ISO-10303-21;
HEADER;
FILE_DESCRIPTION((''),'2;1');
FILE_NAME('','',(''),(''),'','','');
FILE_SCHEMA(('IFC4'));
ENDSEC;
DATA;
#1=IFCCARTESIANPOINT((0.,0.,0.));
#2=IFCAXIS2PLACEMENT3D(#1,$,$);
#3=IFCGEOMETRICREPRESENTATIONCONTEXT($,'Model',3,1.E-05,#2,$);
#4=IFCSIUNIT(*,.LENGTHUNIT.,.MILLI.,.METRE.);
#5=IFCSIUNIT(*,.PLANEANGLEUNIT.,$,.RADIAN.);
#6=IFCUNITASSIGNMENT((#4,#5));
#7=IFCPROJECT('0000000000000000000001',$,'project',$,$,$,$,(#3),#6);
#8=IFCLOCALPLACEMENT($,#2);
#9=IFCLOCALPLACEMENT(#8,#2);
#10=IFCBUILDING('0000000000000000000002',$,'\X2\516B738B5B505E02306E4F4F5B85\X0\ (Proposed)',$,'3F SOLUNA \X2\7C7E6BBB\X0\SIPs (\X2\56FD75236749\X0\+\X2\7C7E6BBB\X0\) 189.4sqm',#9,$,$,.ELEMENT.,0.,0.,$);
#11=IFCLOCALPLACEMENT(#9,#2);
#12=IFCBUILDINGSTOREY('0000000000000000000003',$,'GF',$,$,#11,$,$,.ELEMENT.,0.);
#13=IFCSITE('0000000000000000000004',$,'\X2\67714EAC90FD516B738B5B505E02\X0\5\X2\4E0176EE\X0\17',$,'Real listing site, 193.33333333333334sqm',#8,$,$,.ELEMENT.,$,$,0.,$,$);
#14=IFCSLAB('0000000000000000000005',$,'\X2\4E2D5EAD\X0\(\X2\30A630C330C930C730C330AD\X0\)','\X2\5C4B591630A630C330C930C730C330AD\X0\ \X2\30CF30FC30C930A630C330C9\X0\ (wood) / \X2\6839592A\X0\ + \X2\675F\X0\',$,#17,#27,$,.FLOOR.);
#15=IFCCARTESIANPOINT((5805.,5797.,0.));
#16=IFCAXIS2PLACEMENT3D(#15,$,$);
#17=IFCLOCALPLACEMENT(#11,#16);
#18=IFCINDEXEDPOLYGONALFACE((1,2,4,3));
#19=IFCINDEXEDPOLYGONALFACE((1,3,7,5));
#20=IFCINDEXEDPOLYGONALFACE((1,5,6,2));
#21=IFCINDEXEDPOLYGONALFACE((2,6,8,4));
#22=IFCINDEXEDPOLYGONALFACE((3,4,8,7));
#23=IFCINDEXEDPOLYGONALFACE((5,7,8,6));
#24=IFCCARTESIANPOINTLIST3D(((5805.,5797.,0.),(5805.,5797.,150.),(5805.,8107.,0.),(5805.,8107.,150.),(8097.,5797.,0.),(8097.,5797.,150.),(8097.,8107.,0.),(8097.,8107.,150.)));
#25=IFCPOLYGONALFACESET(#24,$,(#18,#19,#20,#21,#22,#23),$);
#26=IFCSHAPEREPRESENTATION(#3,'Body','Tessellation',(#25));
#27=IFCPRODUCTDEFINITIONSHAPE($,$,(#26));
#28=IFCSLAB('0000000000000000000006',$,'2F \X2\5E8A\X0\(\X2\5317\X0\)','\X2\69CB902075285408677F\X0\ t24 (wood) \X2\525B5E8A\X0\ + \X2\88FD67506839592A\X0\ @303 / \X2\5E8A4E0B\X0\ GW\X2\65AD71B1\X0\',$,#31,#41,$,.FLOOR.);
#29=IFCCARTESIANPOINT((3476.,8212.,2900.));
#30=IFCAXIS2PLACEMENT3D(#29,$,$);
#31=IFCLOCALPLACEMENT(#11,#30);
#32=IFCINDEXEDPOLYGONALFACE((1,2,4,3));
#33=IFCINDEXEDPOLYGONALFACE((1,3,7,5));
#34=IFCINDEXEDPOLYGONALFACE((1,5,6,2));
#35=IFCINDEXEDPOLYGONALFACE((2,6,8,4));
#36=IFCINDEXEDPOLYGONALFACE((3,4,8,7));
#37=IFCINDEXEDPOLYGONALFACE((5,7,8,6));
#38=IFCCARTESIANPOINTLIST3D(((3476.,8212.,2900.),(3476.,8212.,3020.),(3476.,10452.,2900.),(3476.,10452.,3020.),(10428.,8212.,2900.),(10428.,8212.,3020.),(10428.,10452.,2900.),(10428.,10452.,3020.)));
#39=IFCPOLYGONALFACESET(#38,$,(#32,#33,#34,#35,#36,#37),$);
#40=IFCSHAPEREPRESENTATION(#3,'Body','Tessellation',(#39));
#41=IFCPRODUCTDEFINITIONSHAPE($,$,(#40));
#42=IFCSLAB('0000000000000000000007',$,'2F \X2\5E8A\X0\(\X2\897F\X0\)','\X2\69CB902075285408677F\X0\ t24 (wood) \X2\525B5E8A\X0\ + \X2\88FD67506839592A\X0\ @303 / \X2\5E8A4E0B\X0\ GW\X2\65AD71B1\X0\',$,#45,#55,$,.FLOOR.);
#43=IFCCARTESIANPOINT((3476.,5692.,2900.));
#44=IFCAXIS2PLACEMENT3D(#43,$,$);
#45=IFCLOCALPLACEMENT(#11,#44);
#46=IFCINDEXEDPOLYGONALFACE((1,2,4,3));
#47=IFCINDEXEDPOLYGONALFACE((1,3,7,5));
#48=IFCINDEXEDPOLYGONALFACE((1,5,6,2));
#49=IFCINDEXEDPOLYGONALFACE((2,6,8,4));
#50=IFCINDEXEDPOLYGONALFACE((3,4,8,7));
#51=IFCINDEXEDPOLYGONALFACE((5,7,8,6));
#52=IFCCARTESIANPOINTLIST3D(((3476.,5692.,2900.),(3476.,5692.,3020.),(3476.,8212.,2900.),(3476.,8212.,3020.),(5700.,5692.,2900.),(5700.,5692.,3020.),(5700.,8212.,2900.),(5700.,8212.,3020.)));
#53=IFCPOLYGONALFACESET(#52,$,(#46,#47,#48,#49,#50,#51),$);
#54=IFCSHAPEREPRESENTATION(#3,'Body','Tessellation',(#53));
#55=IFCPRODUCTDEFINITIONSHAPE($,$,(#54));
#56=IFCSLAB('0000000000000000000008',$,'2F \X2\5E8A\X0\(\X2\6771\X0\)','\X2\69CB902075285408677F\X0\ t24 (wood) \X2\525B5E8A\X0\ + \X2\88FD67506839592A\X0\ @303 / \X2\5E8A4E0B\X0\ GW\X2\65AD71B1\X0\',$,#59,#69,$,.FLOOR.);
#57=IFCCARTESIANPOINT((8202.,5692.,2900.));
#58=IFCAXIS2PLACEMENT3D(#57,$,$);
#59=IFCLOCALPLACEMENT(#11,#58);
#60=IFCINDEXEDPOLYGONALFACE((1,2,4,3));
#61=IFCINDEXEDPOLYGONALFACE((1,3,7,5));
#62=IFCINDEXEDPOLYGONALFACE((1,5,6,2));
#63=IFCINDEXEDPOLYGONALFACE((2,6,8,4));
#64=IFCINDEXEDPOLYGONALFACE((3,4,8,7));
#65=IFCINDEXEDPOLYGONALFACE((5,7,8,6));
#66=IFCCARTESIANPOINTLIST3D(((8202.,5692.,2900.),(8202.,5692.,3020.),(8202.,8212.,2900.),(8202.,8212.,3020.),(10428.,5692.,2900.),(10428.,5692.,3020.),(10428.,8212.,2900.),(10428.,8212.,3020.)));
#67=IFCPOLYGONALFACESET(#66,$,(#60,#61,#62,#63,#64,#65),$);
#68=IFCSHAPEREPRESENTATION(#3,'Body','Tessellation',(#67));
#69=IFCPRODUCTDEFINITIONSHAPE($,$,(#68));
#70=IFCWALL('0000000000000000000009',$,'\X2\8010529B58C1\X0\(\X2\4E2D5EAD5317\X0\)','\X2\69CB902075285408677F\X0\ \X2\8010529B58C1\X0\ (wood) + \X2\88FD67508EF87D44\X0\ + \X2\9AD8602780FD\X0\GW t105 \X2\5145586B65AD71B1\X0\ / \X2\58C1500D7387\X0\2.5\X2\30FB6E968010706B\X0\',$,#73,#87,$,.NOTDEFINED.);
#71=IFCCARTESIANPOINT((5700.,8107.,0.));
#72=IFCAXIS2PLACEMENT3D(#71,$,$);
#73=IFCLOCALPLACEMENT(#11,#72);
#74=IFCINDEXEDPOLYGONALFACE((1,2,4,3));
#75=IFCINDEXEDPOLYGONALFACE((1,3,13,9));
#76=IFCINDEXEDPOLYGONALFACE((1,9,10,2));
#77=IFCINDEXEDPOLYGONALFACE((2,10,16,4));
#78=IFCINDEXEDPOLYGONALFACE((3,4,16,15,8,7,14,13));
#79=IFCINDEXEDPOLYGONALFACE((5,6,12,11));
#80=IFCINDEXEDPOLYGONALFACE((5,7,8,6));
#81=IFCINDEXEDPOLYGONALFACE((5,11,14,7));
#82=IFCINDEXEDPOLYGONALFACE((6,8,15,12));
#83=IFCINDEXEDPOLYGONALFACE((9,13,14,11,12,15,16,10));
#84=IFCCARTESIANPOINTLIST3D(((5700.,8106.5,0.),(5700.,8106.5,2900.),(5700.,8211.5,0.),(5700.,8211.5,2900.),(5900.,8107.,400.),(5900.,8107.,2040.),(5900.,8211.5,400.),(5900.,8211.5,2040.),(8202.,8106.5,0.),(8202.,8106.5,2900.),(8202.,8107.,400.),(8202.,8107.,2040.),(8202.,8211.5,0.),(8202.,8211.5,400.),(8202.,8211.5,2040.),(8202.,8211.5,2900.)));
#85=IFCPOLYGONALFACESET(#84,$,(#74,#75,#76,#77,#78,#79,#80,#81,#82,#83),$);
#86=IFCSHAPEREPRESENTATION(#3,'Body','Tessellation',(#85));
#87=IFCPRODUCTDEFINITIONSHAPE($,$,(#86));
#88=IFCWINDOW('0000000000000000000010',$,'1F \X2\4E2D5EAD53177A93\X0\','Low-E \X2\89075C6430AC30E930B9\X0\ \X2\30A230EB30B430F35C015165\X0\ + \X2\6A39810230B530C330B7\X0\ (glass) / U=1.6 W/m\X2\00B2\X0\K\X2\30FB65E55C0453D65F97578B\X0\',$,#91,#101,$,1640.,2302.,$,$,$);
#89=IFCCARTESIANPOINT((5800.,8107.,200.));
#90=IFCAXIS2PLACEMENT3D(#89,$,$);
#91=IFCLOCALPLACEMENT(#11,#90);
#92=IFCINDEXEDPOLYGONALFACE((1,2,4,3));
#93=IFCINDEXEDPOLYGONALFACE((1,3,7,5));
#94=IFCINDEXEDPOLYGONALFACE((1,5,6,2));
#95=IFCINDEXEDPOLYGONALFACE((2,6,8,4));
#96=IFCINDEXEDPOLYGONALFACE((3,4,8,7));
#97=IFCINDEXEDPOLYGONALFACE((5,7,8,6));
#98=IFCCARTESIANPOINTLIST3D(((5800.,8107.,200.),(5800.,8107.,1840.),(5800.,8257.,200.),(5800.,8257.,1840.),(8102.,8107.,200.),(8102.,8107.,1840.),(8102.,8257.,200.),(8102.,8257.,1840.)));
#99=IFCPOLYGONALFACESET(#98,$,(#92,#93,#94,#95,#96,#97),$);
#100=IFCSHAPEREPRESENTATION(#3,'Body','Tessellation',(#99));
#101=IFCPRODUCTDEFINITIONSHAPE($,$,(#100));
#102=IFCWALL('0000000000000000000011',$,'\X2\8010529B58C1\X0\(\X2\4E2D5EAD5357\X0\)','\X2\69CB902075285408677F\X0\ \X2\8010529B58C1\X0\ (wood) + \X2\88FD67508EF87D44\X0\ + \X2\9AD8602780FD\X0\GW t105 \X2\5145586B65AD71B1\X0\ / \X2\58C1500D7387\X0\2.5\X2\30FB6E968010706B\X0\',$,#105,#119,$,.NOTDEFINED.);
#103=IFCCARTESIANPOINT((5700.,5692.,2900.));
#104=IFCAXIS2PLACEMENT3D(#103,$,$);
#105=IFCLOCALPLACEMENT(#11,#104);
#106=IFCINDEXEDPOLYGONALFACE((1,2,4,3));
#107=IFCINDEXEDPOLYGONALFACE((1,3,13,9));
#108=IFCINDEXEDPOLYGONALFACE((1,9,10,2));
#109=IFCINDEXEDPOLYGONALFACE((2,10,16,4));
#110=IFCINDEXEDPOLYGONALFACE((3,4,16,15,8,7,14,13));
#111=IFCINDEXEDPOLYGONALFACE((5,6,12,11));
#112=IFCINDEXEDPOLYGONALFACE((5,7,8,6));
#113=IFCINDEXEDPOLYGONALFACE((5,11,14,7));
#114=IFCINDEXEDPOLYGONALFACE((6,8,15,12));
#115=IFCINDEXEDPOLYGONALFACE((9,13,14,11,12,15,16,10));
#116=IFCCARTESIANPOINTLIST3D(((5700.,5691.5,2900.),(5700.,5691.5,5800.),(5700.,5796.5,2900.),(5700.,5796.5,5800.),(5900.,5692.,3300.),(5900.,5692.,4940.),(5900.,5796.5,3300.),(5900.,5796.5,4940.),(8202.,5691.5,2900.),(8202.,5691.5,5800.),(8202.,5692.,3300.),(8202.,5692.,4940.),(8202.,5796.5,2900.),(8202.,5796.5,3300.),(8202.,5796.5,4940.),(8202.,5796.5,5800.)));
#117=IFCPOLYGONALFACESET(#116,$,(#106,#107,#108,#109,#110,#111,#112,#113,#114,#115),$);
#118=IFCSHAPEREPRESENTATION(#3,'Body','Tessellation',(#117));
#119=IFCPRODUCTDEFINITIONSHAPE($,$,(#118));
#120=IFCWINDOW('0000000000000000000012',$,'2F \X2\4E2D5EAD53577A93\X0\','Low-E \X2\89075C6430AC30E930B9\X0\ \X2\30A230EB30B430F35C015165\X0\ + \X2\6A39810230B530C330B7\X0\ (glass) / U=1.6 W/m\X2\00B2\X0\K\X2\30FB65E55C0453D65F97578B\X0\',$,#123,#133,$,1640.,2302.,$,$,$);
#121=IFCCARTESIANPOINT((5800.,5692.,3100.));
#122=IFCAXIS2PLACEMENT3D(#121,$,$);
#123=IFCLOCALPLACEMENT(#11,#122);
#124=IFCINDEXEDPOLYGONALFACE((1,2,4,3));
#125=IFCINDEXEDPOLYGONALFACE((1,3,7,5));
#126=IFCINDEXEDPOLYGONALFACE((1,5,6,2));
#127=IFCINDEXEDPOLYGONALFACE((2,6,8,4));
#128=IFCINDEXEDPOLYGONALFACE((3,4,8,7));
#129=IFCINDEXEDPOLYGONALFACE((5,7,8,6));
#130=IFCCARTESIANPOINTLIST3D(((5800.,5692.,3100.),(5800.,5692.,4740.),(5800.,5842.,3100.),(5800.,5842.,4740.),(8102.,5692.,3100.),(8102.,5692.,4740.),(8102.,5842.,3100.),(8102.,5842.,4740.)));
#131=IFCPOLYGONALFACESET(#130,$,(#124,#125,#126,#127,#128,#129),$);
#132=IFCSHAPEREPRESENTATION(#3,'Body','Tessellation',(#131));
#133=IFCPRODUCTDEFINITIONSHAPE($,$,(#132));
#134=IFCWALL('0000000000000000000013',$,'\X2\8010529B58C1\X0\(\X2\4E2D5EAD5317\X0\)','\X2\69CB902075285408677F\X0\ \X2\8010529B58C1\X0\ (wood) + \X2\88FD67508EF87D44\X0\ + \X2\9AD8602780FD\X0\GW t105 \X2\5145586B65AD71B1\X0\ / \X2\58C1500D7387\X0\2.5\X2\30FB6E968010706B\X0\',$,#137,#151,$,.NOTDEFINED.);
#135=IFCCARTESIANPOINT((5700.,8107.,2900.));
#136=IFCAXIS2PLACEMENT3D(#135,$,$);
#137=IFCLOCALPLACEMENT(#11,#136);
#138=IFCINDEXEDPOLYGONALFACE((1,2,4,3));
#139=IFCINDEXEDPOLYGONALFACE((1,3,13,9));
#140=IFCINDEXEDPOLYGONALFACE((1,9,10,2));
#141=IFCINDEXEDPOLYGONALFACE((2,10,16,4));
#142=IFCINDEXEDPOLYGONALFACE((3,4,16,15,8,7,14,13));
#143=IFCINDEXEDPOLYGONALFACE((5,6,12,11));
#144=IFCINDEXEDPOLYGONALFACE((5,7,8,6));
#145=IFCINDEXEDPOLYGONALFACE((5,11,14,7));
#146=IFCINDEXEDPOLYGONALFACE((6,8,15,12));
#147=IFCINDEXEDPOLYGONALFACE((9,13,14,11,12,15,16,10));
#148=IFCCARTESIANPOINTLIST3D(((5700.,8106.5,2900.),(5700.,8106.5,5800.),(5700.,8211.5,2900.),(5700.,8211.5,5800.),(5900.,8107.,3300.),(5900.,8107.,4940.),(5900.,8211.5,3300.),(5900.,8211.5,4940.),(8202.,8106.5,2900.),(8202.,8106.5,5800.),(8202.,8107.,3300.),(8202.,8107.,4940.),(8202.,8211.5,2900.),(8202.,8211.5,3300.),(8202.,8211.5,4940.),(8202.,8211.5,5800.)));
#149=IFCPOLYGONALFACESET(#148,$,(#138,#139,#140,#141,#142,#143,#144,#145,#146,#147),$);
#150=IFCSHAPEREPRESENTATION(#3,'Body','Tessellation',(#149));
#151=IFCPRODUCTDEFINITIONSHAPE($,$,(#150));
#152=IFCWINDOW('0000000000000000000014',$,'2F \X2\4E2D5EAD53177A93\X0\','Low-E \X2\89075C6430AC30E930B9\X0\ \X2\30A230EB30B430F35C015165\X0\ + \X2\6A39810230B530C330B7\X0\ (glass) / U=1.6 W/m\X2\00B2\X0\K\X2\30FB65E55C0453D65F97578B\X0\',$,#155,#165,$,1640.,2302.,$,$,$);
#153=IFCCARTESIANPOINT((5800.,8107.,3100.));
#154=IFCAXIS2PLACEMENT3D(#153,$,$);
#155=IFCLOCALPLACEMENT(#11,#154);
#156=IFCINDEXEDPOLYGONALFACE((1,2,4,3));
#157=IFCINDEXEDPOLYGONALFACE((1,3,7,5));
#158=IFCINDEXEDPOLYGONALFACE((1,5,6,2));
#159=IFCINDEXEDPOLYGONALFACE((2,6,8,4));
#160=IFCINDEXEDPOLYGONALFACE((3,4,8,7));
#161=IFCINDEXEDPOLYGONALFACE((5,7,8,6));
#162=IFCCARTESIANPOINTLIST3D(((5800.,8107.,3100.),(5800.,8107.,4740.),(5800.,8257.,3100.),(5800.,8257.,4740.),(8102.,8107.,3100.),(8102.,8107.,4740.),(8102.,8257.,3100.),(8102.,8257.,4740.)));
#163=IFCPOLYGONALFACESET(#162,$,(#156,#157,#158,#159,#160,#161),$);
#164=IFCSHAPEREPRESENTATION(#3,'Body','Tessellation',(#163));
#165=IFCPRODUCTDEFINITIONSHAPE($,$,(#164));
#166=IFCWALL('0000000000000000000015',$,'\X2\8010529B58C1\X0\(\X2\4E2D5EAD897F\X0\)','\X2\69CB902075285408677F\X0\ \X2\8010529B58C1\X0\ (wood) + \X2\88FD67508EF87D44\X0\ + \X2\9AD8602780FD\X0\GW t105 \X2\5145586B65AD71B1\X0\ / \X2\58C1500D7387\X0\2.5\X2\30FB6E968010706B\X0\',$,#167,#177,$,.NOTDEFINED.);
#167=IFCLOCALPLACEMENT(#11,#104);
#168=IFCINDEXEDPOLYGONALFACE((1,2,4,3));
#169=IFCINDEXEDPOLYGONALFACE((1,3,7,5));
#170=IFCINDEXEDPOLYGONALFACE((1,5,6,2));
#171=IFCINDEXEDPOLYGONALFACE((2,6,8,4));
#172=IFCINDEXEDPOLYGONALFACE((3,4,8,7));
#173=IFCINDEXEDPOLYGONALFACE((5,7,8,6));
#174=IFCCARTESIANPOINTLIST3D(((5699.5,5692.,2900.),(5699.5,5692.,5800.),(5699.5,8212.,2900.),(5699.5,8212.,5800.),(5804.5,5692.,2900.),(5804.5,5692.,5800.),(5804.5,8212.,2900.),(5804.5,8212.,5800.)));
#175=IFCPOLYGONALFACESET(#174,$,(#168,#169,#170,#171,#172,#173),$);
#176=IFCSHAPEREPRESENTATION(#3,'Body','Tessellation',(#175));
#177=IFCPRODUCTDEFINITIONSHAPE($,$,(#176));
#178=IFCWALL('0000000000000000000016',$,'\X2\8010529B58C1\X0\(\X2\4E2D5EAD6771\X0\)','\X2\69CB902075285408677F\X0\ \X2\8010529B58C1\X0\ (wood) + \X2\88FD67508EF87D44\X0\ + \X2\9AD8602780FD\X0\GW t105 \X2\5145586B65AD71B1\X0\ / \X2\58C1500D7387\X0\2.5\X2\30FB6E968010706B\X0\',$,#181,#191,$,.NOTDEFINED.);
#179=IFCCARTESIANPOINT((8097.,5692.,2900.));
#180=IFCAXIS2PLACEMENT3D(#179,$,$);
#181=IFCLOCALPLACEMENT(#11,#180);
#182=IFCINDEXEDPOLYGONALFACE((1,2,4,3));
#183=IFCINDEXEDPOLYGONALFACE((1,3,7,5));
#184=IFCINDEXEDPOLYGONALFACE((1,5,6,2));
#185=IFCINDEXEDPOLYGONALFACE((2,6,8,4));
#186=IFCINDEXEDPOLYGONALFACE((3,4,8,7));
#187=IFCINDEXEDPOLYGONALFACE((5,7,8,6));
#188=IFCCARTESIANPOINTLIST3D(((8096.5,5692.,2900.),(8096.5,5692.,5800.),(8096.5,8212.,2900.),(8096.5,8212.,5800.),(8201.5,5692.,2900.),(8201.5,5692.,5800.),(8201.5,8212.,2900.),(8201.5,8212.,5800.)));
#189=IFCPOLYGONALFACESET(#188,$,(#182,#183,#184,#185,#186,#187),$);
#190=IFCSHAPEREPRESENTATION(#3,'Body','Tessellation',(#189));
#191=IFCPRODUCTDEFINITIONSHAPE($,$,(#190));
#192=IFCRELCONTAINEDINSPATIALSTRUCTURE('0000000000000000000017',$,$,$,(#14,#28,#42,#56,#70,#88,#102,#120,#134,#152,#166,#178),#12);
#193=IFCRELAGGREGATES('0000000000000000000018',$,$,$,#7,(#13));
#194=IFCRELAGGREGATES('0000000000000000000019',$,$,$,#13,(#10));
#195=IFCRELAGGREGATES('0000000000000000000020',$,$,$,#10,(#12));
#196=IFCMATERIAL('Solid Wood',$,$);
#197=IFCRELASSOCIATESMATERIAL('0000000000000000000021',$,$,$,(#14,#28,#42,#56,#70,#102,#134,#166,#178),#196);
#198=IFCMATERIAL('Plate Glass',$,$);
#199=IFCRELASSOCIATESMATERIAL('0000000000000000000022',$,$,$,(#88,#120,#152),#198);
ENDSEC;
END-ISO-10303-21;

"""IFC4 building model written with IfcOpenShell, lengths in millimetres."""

from ifc_helpers import new_model, si_unit, frame, frame_2d, origin, place, context, project, spatial, rectangle, extrude, material, element, fill, save


model = new_model("IFC4")

# Units and contexts
model_context = context("Model", 3, precision=1e-05, world=origin())
ifc_project = project(units=[si_unit("LENGTHUNIT", "METRE", prefix="MILLI"), si_unit("PLANEANGLEUNIT", "RADIAN")], contexts=[model_context])

# Site, building, storey
site_placement = place(None, origin())
site = spatial("IfcSite", under=ifc_project, at=site_placement, Name="東京都八王子市5丁目17", ObjectType="Real listing site, 193.33333333333334sqm", CompositionType="ELEMENT", RefElevation=0.0)
building_placement = place(site_placement, origin())
building = spatial("IfcBuilding", under=site, at=building_placement, Name="八王子市の住宅 (Proposed)", ObjectType="3F SOLUNA 籾殻SIPs (国産杉+籾殻) 189.4sqm", CompositionType="ELEMENT", ElevationOfRefHeight=0.0, ElevationOfTerrain=0.0)
storey_placement = place(building_placement, origin())
storey = spatial("IfcBuildingStorey", under=building, at=storey_placement, Name="GF", CompositionType="ELEMENT", Elevation=0.0)

# Slabs
ifc_material_1 = material(Name="Solid Wood")
slab_1_placement = place(storey_placement, frame((5805.0, 5797.0, 0.0)))
element("IfcSlab", 1, at=slab_1_placement, inside=storey, material=ifc_material_1, Name="中庭(ウッドデッキ)", Description="屋外ウッドデッキ ハードウッド (wood) / 根太 + 束", PredefinedType="FLOOR", context=model_context, shape_type="SweptSolid", body=[
    extrude(rectangle(XDim=2292.0, YDim=2310.0, at=frame_2d((1146.0, 1155.0))), frame((5805.0, 5797.0, 0.0)), (0.0, 0.0, 1.0), 150.0),
])
slab_2_placement = place(storey_placement, frame((3476.0, 8212.0, 2900.0)))
element("IfcSlab", 2, at=slab_2_placement, inside=storey, material=ifc_material_1, Name="2F 床(北)", Description="構造用合板 t24 (wood) 剛床 + 製材根太 @303 / 床下 GW断熱", PredefinedType="FLOOR", context=model_context, shape_type="SweptSolid", body=[
    extrude(rectangle(XDim=6952.0, YDim=2240.0, at=frame_2d((3476.0, 1120.0))), frame((3476.0, 8212.0, 2900.0)), (0.0, 0.0, 1.0), 120.0),
])
slab_3_placement = place(storey_placement, frame((3476.0, 5692.0, 2900.0)))
element("IfcSlab", 3, at=slab_3_placement, inside=storey, material=ifc_material_1, Name="2F 床(西)", Description="構造用合板 t24 (wood) 剛床 + 製材根太 @303 / 床下 GW断熱", PredefinedType="FLOOR", context=model_context, shape_type="SweptSolid", body=[
    extrude(rectangle(XDim=2224.0, YDim=2520.0, at=frame_2d((1112.0, 1260.0))), frame((3476.0, 5692.0, 2900.0)), (0.0, 0.0, 1.0), 120.0),
])
slab_4_placement = place(storey_placement, frame((8202.0, 5692.0, 2900.0)))
element("IfcSlab", 4, at=slab_4_placement, inside=storey, material=ifc_material_1, Name="2F 床(東)", Description="構造用合板 t24 (wood) 剛床 + 製材根太 @303 / 床下 GW断熱", PredefinedType="FLOOR", context=model_context, shape_type="SweptSolid", body=[
    extrude(rectangle(XDim=2226.0, YDim=2520.0, at=frame_2d((1113.0, 1260.0))), frame((8202.0, 5692.0, 2900.0)), (0.0, 0.0, 1.0), 120.0),
])

# Wall, opening, window
wall_1_placement = place(storey_placement, frame((5700.0, 8107.0, 0.0)))
wall_1 = element("IfcWall", 5, at=wall_1_placement, inside=storey, material=ifc_material_1, Name="耐力壁(中庭北)", Description="構造用合板 耐力壁 (wood) + 製材軸組 + 高性能GW t105 充填断熱 / 壁倍率2.5・準耐火", PredefinedType="NOTDEFINED", context=model_context, shape_type="SweptSolid", body=[
    extrude(rectangle(XDim=2502.0, YDim=105.0, at=frame_2d((1251.0, 52.0))), frame((5700.0, 8107.0, 0.0)), (0.0, 0.0, 1.0), 2900.0),
])
opening_1_placement = place(storey_placement, frame((5800.0, 8107.0, 200.0)))
opening_1 = element("IfcOpeningElement", 6, at=opening_1_placement, cuts=wall_1, PredefinedType="NOTDEFINED", context=model_context, shape_type="SweptSolid", body=[
    extrude(rectangle(XDim=2302.0, YDim=150.0, at=frame_2d((1151.0, 75.0))), frame((5800.0, 8107.0, 200.0)), (0.0, 0.0, 1.0), 1640.0),
])
ifc_material_2 = material(Name="Plate Glass")
window_1_placement = place(storey_placement, frame((5800.0, 8107.0, 200.0)))
window_1 = element("IfcWindow", 7, at=window_1_placement, inside=storey, material=ifc_material_2, Name="1F 中庭北窓", Description="Low-E 複層ガラス アルゴン封入 + 樹脂サッシ (glass) / U=1.6 W/m²K・日射取得型", OverallHeight=1640.0, OverallWidth=2302.0, context=model_context, shape_type="SweptSolid", body=[
    extrude(rectangle(XDim=2302.0, YDim=150.0, at=frame_2d((1151.0, 75.0))), frame((5800.0, 8107.0, 200.0)), (0.0, 0.0, 1.0), 1640.0),
])
fill(opening_1, window_1)

# Walls, openings, windows
wall_2_placement = place(storey_placement, frame((5700.0, 5692.0, 2900.0)))
wall_2 = element("IfcWall", 8, at=wall_2_placement, inside=storey, material=ifc_material_1, Name="耐力壁(中庭南)", Description="構造用合板 耐力壁 (wood) + 製材軸組 + 高性能GW t105 充填断熱 / 壁倍率2.5・準耐火", PredefinedType="NOTDEFINED", context=model_context, shape_type="SweptSolid", body=[
    extrude(rectangle(XDim=2502.0, YDim=105.0, at=frame_2d((1251.0, 52.0))), frame((5700.0, 5692.0, 2900.0)), (0.0, 0.0, 1.0), 2900.0),
])
opening_2_placement = place(storey_placement, frame((5800.0, 5692.0, 3100.0)))
opening_2 = element("IfcOpeningElement", 9, at=opening_2_placement, cuts=wall_2, PredefinedType="NOTDEFINED", context=model_context, shape_type="SweptSolid", body=[
    extrude(rectangle(XDim=2302.0, YDim=150.0, at=frame_2d((1151.0, 75.0))), frame((5800.0, 5692.0, 3100.0)), (0.0, 0.0, 1.0), 1640.0),
])
window_2_placement = place(storey_placement, frame((5800.0, 5692.0, 3100.0)))
window_2 = element("IfcWindow", 10, at=window_2_placement, inside=storey, material=ifc_material_2, Name="2F 中庭南窓", Description="Low-E 複層ガラス アルゴン封入 + 樹脂サッシ (glass) / U=1.6 W/m²K・日射取得型", OverallHeight=1640.0, OverallWidth=2302.0, context=model_context, shape_type="SweptSolid", body=[
    extrude(rectangle(XDim=2302.0, YDim=150.0, at=frame_2d((1151.0, 75.0))), frame((5800.0, 5692.0, 3100.0)), (0.0, 0.0, 1.0), 1640.0),
])
fill(opening_2, window_2)
wall_3_placement = place(storey_placement, frame((5700.0, 8107.0, 2900.0)))
wall_3 = element("IfcWall", 11, at=wall_3_placement, inside=storey, material=ifc_material_1, Name="耐力壁(中庭北)", Description="構造用合板 耐力壁 (wood) + 製材軸組 + 高性能GW t105 充填断熱 / 壁倍率2.5・準耐火", PredefinedType="NOTDEFINED", context=model_context, shape_type="SweptSolid", body=[
    extrude(rectangle(XDim=2502.0, YDim=105.0, at=frame_2d((1251.0, 52.0))), frame((5700.0, 8107.0, 2900.0)), (0.0, 0.0, 1.0), 2900.0),
])
opening_3_placement = place(storey_placement, frame((5800.0, 8107.0, 3100.0)))
opening_3 = element("IfcOpeningElement", 12, at=opening_3_placement, cuts=wall_3, PredefinedType="NOTDEFINED", context=model_context, shape_type="SweptSolid", body=[
    extrude(rectangle(XDim=2302.0, YDim=150.0, at=frame_2d((1151.0, 75.0))), frame((5800.0, 8107.0, 3100.0)), (0.0, 0.0, 1.0), 1640.0),
])
window_3_placement = place(storey_placement, frame((5800.0, 8107.0, 3100.0)))
window_3 = element("IfcWindow", 13, at=window_3_placement, inside=storey, material=ifc_material_2, Name="2F 中庭北窓", Description="Low-E 複層ガラス アルゴン封入 + 樹脂サッシ (glass) / U=1.6 W/m²K・日射取得型", OverallHeight=1640.0, OverallWidth=2302.0, context=model_context, shape_type="SweptSolid", body=[
    extrude(rectangle(XDim=2302.0, YDim=150.0, at=frame_2d((1151.0, 75.0))), frame((5800.0, 8107.0, 3100.0)), (0.0, 0.0, 1.0), 1640.0),
])
fill(opening_3, window_3)

# Walls
wall_4_placement = place(storey_placement, frame((5700.0, 5692.0, 2900.0)))
element("IfcWall", 14, at=wall_4_placement, inside=storey, material=ifc_material_1, Name="耐力壁(中庭西)", Description="構造用合板 耐力壁 (wood) + 製材軸組 + 高性能GW t105 充填断熱 / 壁倍率2.5・準耐火", PredefinedType="NOTDEFINED", context=model_context, shape_type="SweptSolid", body=[
    extrude(rectangle(XDim=105.0, YDim=2520.0, at=frame_2d((52.0, 1260.0))), frame((5700.0, 5692.0, 2900.0)), (0.0, 0.0, 1.0), 2900.0),
])
wall_5_placement = place(storey_placement, frame((8097.0, 5692.0, 2900.0)))
element("IfcWall", 15, at=wall_5_placement, inside=storey, material=ifc_material_1, Name="耐力壁(中庭東)", Description="構造用合板 耐力壁 (wood) + 製材軸組 + 高性能GW t105 充填断熱 / 壁倍率2.5・準耐火", PredefinedType="NOTDEFINED", context=model_context, shape_type="SweptSolid", body=[
    extrude(rectangle(XDim=105.0, YDim=2520.0, at=frame_2d((52.0, 1260.0))), frame((8097.0, 5692.0, 2900.0)), (0.0, 0.0, 1.0), 2900.0),
])

save(model, "model.ifc")
